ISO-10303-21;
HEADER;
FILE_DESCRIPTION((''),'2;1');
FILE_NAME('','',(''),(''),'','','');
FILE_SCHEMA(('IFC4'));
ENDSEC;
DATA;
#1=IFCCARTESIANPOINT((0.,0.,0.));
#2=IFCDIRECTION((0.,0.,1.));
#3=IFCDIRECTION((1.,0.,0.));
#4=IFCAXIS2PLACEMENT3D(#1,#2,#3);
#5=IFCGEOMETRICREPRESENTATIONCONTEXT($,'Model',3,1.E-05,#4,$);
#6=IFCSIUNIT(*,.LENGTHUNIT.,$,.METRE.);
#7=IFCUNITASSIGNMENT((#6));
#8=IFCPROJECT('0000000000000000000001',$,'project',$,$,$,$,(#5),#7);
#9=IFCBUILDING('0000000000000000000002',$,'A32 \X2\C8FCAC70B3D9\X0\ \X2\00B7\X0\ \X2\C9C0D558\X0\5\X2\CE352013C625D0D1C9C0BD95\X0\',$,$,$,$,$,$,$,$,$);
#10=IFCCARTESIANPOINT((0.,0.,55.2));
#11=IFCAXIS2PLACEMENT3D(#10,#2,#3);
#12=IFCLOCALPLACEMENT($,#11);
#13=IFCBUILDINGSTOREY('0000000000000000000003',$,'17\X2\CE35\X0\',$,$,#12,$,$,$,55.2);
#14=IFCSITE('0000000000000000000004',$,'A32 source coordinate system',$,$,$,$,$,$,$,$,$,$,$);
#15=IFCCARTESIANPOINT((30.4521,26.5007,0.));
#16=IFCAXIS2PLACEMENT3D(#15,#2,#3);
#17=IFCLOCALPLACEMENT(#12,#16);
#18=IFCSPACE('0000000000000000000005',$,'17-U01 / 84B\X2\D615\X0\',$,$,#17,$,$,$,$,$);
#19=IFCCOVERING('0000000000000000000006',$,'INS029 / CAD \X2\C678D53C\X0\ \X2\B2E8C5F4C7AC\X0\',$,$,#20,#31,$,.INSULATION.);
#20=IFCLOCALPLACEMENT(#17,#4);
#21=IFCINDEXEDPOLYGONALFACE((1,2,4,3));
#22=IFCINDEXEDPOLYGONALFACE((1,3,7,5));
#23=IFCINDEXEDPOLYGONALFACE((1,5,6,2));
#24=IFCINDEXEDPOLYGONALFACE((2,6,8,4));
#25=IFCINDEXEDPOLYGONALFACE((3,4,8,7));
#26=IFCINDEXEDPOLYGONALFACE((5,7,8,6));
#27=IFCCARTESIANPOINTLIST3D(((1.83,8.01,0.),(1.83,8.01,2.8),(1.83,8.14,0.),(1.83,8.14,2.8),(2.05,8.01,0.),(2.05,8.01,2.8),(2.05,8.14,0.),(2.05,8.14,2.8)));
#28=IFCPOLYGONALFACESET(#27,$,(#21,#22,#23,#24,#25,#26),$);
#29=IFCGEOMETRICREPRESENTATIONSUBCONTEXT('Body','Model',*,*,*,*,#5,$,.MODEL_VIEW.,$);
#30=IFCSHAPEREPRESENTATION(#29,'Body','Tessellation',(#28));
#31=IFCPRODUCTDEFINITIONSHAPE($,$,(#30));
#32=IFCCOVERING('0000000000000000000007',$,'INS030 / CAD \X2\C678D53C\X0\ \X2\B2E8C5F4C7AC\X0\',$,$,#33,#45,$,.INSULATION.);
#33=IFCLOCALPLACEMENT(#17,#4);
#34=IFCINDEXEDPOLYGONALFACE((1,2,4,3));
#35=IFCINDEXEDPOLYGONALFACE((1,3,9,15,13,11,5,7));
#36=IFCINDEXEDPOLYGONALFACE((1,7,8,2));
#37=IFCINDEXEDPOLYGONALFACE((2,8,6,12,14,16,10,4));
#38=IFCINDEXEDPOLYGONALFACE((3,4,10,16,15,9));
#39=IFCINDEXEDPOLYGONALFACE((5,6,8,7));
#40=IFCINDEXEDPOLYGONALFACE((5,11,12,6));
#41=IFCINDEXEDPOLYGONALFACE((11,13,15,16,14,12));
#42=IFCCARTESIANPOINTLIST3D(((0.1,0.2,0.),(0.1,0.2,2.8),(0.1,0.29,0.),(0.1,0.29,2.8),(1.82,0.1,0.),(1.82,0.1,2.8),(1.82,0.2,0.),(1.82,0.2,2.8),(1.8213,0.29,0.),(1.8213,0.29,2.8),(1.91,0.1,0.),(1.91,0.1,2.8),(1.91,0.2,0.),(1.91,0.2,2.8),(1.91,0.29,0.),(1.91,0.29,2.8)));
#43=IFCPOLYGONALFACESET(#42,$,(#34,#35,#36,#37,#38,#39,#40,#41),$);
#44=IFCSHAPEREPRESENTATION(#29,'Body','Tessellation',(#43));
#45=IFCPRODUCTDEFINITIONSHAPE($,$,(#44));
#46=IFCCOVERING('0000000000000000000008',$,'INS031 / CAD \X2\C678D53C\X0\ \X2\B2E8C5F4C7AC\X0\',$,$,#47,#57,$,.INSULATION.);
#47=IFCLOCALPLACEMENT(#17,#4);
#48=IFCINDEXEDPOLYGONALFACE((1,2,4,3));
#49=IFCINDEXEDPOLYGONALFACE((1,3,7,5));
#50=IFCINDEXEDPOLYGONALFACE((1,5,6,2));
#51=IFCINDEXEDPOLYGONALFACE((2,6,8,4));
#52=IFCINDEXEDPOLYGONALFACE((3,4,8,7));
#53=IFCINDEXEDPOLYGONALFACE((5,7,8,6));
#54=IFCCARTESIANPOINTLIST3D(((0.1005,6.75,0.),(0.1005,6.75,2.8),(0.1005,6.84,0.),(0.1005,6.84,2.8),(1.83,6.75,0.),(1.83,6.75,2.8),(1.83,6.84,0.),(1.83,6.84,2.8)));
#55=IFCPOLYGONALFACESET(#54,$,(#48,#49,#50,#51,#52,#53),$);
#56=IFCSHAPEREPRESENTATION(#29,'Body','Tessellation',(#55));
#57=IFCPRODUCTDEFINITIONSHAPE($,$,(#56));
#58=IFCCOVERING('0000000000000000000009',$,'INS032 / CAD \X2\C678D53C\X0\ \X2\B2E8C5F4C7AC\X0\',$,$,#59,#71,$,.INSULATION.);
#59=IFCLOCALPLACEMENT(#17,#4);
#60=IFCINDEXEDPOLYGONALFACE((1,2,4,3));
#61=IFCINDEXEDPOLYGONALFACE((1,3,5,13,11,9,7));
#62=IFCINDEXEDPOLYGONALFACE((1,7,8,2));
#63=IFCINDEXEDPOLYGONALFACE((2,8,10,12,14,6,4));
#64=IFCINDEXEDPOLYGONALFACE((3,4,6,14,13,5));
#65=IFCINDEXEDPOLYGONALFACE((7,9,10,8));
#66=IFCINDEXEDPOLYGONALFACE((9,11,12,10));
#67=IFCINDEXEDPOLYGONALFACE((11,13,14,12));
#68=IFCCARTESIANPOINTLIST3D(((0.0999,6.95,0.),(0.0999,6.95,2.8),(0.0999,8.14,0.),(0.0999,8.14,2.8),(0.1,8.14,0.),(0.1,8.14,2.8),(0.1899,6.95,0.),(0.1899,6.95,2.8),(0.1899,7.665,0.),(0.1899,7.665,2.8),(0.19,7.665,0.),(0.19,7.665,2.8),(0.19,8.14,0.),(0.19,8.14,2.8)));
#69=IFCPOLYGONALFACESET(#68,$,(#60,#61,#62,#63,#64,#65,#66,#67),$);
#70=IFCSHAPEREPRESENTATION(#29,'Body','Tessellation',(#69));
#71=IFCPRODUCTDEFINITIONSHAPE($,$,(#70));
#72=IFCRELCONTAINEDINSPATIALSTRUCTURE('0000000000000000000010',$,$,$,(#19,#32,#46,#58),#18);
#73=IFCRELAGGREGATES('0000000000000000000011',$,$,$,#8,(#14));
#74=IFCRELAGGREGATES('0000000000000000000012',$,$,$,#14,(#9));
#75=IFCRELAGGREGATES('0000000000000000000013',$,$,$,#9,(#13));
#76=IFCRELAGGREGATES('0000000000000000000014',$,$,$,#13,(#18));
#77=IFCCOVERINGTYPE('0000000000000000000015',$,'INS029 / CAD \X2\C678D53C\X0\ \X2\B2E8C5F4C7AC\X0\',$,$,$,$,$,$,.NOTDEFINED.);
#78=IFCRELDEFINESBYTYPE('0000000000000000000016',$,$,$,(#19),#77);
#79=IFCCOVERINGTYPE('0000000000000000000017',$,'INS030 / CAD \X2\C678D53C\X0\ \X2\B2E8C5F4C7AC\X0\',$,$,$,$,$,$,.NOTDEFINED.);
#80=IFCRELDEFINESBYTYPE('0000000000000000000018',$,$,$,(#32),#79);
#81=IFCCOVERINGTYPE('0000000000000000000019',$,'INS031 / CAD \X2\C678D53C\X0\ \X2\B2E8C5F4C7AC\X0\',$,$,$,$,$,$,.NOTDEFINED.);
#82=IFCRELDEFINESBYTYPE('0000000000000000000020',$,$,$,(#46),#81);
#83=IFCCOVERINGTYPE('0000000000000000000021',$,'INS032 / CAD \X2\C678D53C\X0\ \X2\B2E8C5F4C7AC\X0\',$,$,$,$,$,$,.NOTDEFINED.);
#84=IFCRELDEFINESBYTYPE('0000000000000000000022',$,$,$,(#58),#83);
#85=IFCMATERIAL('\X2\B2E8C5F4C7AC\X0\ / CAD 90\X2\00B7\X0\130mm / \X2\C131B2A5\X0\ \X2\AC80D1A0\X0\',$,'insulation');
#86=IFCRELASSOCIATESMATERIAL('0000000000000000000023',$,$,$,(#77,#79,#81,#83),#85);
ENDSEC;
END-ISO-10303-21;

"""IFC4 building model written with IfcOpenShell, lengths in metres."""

from ifc_helpers import new_model, si_unit, frame, origin, origin_with_axes, place, context, subcontext, project, spatial, polyline, outline, extrude, source, transform, mapped, material, type_object, type_shapes, element, save


model = new_model("IFC4")

# Units and contexts
model_context = context("Model", 3, precision=1e-05, world=origin_with_axes())
body_context = subcontext(model_context, "Body", "Model", "MODEL_VIEW")
ifc_project = project(units=[si_unit("LENGTHUNIT", "METRE")], contexts=[model_context])

# Site, building, storey, space
storey_placement = place(None, frame((0.0, 0.0, 55.2), z_axis=(0.0, 0.0, 1.0), x_axis=(1.0, 0.0, 0.0)))
space_placement = place(storey_placement, frame((30.4521, 26.5007, 0.0), z_axis=(0.0, 0.0, 1.0), x_axis=(1.0, 0.0, 0.0)))
site = spatial("IfcSite", under=ifc_project, Name="A32 source coordinate system")
building = spatial("IfcBuilding", under=site, Name="A32 주거동 · 지하5층–옥탑지붕")
storey = spatial("IfcBuildingStorey", under=building, at=storey_placement, Name="17층", Elevation=55.2)
space = spatial("IfcSpace", under=storey, at=space_placement, Name="17-U01 / 84B형")

# Coverings
ifc_material = material(Name="단열재 / CAD 90·130mm / 성능 검토", Category="insulation")
covering_type_1 = type_object("IfcCoveringType", Name="INS029 / CAD 외피 단열재", PredefinedType="NOTDEFINED", material=ifc_material)
shared_shape_1 = source(origin(), body_context, "Body", "SweptSolid", [
    extrude(outline(polyline([(1.83, 8.01), (1.83, 8.14), (2.05, 8.14), (2.05, 8.01), (1.83, 8.01)])), origin(), (0.0, 0.0, 1.0), 2.8),
])
type_shapes(covering_type_1, [shared_shape_1])
covering_1_placement = place(space_placement, origin_with_axes())
element("IfcCovering", 1, at=covering_1_placement, inside=space, type_object=covering_type_1, Name="INS029 / CAD 외피 단열재", PredefinedType="INSULATION", context=body_context, shape_type="MappedRepresentation", body=[
    mapped(shared_shape_1, transform((0.0, 0.0, 0.0), scale=1.0)),
])
covering_type_2 = type_object("IfcCoveringType", Name="INS030 / CAD 외피 단열재", PredefinedType="NOTDEFINED", material=ifc_material)
shared_shape_2 = source(origin(), body_context, "Body", "SweptSolid", [
    extrude(outline(polyline([(1.91, 0.2), (1.91, 0.1), (1.82, 0.1), (1.82, 0.2), (0.1, 0.2), (0.1, 0.29), (1.8213, 0.29), (1.91, 0.29), (1.91, 0.2)])), origin(), (0.0, 0.0, 1.0), 2.8),
])
type_shapes(covering_type_2, [shared_shape_2])
covering_2_placement = place(space_placement, origin_with_axes())
element("IfcCovering", 2, at=covering_2_placement, inside=space, type_object=covering_type_2, Name="INS030 / CAD 외피 단열재", PredefinedType="INSULATION", context=body_context, shape_type="MappedRepresentation", body=[
    mapped(shared_shape_2, transform((0.0, 0.0, 0.0), scale=1.0)),
])
covering_type_3 = type_object("IfcCoveringType", Name="INS031 / CAD 외피 단열재", PredefinedType="NOTDEFINED", material=ifc_material)
shared_shape_3 = source(origin(), body_context, "Body", "SweptSolid", [
    extrude(outline(polyline([(1.83, 6.75), (0.1005, 6.75), (0.1005, 6.84), (1.83, 6.84), (1.83, 6.75)])), origin(), (0.0, 0.0, 1.0), 2.8),
])
type_shapes(covering_type_3, [shared_shape_3])
covering_3_placement = place(space_placement, origin_with_axes())
element("IfcCovering", 3, at=covering_3_placement, inside=space, type_object=covering_type_3, Name="INS031 / CAD 외피 단열재", PredefinedType="INSULATION", context=body_context, shape_type="MappedRepresentation", body=[
    mapped(shared_shape_3, transform((0.0, 0.0, 0.0), scale=1.0)),
])
covering_type_4 = type_object("IfcCoveringType", Name="INS032 / CAD 외피 단열재", PredefinedType="NOTDEFINED", material=ifc_material)
shared_shape_4 = source(origin(), body_context, "Body", "SweptSolid", [
    extrude(outline(polyline([(0.1899, 6.95), (0.0999, 6.95), (0.0999, 8.14), (0.1, 8.14), (0.19, 8.14), (0.19, 7.665), (0.1899, 7.665), (0.1899, 6.95)])), origin(), (0.0, 0.0, 1.0), 2.8),
])
type_shapes(covering_type_4, [shared_shape_4])
covering_4_placement = place(space_placement, origin_with_axes())
element("IfcCovering", 4, at=covering_4_placement, inside=space, type_object=covering_type_4, Name="INS032 / CAD 외피 단열재", PredefinedType="INSULATION", context=body_context, shape_type="MappedRepresentation", body=[
    mapped(shared_shape_4, transform((0.0, 0.0, 0.0), scale=1.0)),
])

save(model, "model.ifc")
